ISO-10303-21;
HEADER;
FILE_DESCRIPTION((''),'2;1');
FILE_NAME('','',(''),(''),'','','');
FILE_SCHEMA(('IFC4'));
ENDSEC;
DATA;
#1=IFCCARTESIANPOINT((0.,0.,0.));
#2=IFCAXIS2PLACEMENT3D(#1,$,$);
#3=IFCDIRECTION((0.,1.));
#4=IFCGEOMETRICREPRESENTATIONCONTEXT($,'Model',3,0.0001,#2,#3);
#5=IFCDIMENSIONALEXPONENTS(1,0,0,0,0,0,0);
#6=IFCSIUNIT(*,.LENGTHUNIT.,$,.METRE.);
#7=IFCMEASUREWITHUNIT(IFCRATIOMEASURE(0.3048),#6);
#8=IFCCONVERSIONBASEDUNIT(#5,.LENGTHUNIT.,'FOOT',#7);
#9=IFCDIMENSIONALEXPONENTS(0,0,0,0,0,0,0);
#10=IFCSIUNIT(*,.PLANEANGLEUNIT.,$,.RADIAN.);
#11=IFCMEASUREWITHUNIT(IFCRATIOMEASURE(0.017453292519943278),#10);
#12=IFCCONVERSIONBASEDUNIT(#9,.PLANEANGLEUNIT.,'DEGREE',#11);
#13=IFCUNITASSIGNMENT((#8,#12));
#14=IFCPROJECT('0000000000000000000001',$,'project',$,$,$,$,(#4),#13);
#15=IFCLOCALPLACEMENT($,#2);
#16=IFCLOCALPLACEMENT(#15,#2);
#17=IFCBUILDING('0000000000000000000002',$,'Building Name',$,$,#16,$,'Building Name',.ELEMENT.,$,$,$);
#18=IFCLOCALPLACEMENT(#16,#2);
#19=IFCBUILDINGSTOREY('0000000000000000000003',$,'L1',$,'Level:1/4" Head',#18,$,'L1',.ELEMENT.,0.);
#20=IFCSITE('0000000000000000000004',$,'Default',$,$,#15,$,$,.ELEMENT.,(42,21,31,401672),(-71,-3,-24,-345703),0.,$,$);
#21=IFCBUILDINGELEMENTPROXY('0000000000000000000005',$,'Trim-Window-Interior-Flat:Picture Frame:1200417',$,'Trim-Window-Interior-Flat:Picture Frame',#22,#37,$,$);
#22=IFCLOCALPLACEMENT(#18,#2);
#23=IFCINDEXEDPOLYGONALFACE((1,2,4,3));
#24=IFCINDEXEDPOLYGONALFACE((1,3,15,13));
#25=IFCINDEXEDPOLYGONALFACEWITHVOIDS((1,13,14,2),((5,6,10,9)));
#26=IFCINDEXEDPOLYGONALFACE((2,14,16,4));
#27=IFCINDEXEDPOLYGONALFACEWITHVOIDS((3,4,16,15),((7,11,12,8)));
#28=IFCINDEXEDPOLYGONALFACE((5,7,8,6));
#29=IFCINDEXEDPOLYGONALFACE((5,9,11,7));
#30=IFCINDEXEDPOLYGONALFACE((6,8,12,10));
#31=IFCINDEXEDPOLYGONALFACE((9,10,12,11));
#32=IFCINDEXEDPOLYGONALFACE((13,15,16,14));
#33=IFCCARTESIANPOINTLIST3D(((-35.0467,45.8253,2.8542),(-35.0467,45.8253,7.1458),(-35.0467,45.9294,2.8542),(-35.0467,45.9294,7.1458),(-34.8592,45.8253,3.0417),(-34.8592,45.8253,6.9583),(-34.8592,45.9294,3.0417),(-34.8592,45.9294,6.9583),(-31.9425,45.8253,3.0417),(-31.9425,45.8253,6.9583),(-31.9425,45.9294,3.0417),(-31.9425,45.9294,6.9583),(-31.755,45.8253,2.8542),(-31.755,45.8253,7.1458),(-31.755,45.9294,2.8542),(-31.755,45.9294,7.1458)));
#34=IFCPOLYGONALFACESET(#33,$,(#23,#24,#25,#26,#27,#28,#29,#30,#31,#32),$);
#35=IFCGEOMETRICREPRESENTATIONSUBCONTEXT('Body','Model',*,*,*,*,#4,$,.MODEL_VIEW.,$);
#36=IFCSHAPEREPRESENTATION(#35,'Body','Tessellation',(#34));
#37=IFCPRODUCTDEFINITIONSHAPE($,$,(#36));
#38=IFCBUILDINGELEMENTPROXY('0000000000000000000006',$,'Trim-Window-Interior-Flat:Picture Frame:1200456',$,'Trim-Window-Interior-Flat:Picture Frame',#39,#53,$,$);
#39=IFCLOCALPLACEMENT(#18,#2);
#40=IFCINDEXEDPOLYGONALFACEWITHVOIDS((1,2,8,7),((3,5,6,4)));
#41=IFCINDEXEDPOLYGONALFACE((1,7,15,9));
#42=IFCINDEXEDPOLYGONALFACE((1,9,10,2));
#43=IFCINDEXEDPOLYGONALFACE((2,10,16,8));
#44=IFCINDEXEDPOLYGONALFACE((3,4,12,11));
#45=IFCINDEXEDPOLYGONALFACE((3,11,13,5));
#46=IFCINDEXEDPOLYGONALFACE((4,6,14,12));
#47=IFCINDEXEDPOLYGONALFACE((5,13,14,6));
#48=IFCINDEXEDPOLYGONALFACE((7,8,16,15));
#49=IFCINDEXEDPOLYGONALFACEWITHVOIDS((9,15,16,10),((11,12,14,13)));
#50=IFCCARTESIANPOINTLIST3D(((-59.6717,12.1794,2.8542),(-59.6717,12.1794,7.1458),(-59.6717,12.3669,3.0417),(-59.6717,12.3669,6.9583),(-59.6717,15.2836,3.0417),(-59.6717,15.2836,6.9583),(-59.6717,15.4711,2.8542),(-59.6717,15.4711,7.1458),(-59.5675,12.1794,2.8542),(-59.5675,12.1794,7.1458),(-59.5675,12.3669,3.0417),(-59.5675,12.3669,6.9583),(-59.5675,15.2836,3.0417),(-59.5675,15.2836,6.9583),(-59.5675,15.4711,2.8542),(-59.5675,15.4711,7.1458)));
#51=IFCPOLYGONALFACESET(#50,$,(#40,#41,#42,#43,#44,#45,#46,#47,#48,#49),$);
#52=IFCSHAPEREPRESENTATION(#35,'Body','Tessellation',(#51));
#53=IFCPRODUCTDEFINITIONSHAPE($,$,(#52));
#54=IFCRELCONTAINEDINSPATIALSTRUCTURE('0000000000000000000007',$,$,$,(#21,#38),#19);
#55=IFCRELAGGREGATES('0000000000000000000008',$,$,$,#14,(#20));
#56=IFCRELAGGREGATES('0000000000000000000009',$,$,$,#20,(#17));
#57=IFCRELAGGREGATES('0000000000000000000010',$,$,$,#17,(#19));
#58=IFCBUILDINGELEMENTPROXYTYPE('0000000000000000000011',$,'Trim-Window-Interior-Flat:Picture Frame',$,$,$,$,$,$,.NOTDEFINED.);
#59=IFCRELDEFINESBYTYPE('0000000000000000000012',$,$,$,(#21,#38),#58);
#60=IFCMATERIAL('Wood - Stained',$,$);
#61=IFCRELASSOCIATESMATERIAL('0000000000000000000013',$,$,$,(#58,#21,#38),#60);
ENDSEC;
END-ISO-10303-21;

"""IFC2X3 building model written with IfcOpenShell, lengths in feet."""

from ifc_helpers import new_model, entity, si_unit, converted_unit, direction, frame, origin, place, context, subcontext, project, spatial, polyline, outline, extrude, source, transform, mapped, material, type_object, type_shapes, element, save


model = new_model("IFC2X3")

# Units and contexts
model_context = context("Model", 3, precision=0.0001, world=origin(), true_north=direction((0.0, 1.0)))
body_context = subcontext(model_context, "Body", "Model", "MODEL_VIEW")
ifc_project = project(units=[converted_unit("LENGTHUNIT", "FOOT", entity("IfcRatioMeasure", 0.3048), si_unit("LENGTHUNIT", "METRE"), dimensions=[1, 0, 0, 0, 0, 0, 0]), converted_unit("PLANEANGLEUNIT", "DEGREE", entity("IfcRatioMeasure", 0.017453292519943278), si_unit("PLANEANGLEUNIT", "RADIAN"), dimensions=[0, 0, 0, 0, 0, 0, 0])], contexts=[model_context])

# Site, building, storey
site_placement = place(None, origin())
site = spatial("IfcSite", under=ifc_project, at=site_placement, Name="Default", CompositionType="ELEMENT", RefLatitude=(42, 21, 31, 401672), RefLongitude=(-71, -3, -24, -345703), RefElevation=0.0)
building_placement = place(site_placement, origin())
building = spatial("IfcBuilding", under=site, at=building_placement, Name="Building Name", LongName="Building Name", CompositionType="ELEMENT")
storey_placement = place(building_placement, origin())
storey = spatial("IfcBuildingStorey", under=building, at=storey_placement, Name="L1", ObjectType="Level:1/4\" Head", LongName="L1", CompositionType="ELEMENT", Elevation=0.0)

# Building element proxies
ifc_material_1 = material(Name="Wood - Stained")
building_element_proxy_type_1 = type_object("IfcBuildingElementProxyType", Name="Trim-Window-Interior-Flat:Picture Frame", PredefinedType="NOTDEFINED", material=ifc_material_1)
shared_shape_1 = source(origin(), body_context, "Body", "SweptSolid", [
    extrude(outline(polyline([(-1.6458, -2.1458), (1.6458, -2.1458), (1.6458, 2.1458), (-1.6458, 2.1458), (-1.6458, -2.1458)]), holes=[polyline([(-1.4583, -1.9583), (-1.4583, 1.9583), (1.4583, 1.9583), (1.4583, -1.9583), (-1.4583, -1.9583)])]), frame((0.0, -2.0, 0.0), z_axis=(0.0, 0.0, 1.0), x_axis=(-1.0, 0.0, 0.0)), (0.0, 0.0, 1.0), 0.1042),
])
type_shapes(building_element_proxy_type_1, [shared_shape_1])
for number, where, z_axis, x_axis, name in (
    (1, (-33.4009, 45.8253, 7.0), (0.0, 1.0, 0.0), (-1.0, 0.0, 0.0), "Trim-Window-Interior-Flat:Picture Frame:1200417"),
    (2, (-59.5675, 13.8253, 7.0), (-1.0, 0.0, 0.0), (0.0, -1.0, 0.0), "Trim-Window-Interior-Flat:Picture Frame:1200456"),
):
    element("IfcBuildingElementProxy", number, at=place(storey_placement, frame(where, z_axis=z_axis, x_axis=x_axis)), inside=storey, type_object=building_element_proxy_type_1, material=ifc_material_1, Name=name, ObjectType="Trim-Window-Interior-Flat:Picture Frame", context=body_context, shape_type="MappedRepresentation", body=[
        mapped(shared_shape_1, transform((0.0, 0.0, 0.0), scale=1.0)),
    ])

save(model, "model.ifc")
